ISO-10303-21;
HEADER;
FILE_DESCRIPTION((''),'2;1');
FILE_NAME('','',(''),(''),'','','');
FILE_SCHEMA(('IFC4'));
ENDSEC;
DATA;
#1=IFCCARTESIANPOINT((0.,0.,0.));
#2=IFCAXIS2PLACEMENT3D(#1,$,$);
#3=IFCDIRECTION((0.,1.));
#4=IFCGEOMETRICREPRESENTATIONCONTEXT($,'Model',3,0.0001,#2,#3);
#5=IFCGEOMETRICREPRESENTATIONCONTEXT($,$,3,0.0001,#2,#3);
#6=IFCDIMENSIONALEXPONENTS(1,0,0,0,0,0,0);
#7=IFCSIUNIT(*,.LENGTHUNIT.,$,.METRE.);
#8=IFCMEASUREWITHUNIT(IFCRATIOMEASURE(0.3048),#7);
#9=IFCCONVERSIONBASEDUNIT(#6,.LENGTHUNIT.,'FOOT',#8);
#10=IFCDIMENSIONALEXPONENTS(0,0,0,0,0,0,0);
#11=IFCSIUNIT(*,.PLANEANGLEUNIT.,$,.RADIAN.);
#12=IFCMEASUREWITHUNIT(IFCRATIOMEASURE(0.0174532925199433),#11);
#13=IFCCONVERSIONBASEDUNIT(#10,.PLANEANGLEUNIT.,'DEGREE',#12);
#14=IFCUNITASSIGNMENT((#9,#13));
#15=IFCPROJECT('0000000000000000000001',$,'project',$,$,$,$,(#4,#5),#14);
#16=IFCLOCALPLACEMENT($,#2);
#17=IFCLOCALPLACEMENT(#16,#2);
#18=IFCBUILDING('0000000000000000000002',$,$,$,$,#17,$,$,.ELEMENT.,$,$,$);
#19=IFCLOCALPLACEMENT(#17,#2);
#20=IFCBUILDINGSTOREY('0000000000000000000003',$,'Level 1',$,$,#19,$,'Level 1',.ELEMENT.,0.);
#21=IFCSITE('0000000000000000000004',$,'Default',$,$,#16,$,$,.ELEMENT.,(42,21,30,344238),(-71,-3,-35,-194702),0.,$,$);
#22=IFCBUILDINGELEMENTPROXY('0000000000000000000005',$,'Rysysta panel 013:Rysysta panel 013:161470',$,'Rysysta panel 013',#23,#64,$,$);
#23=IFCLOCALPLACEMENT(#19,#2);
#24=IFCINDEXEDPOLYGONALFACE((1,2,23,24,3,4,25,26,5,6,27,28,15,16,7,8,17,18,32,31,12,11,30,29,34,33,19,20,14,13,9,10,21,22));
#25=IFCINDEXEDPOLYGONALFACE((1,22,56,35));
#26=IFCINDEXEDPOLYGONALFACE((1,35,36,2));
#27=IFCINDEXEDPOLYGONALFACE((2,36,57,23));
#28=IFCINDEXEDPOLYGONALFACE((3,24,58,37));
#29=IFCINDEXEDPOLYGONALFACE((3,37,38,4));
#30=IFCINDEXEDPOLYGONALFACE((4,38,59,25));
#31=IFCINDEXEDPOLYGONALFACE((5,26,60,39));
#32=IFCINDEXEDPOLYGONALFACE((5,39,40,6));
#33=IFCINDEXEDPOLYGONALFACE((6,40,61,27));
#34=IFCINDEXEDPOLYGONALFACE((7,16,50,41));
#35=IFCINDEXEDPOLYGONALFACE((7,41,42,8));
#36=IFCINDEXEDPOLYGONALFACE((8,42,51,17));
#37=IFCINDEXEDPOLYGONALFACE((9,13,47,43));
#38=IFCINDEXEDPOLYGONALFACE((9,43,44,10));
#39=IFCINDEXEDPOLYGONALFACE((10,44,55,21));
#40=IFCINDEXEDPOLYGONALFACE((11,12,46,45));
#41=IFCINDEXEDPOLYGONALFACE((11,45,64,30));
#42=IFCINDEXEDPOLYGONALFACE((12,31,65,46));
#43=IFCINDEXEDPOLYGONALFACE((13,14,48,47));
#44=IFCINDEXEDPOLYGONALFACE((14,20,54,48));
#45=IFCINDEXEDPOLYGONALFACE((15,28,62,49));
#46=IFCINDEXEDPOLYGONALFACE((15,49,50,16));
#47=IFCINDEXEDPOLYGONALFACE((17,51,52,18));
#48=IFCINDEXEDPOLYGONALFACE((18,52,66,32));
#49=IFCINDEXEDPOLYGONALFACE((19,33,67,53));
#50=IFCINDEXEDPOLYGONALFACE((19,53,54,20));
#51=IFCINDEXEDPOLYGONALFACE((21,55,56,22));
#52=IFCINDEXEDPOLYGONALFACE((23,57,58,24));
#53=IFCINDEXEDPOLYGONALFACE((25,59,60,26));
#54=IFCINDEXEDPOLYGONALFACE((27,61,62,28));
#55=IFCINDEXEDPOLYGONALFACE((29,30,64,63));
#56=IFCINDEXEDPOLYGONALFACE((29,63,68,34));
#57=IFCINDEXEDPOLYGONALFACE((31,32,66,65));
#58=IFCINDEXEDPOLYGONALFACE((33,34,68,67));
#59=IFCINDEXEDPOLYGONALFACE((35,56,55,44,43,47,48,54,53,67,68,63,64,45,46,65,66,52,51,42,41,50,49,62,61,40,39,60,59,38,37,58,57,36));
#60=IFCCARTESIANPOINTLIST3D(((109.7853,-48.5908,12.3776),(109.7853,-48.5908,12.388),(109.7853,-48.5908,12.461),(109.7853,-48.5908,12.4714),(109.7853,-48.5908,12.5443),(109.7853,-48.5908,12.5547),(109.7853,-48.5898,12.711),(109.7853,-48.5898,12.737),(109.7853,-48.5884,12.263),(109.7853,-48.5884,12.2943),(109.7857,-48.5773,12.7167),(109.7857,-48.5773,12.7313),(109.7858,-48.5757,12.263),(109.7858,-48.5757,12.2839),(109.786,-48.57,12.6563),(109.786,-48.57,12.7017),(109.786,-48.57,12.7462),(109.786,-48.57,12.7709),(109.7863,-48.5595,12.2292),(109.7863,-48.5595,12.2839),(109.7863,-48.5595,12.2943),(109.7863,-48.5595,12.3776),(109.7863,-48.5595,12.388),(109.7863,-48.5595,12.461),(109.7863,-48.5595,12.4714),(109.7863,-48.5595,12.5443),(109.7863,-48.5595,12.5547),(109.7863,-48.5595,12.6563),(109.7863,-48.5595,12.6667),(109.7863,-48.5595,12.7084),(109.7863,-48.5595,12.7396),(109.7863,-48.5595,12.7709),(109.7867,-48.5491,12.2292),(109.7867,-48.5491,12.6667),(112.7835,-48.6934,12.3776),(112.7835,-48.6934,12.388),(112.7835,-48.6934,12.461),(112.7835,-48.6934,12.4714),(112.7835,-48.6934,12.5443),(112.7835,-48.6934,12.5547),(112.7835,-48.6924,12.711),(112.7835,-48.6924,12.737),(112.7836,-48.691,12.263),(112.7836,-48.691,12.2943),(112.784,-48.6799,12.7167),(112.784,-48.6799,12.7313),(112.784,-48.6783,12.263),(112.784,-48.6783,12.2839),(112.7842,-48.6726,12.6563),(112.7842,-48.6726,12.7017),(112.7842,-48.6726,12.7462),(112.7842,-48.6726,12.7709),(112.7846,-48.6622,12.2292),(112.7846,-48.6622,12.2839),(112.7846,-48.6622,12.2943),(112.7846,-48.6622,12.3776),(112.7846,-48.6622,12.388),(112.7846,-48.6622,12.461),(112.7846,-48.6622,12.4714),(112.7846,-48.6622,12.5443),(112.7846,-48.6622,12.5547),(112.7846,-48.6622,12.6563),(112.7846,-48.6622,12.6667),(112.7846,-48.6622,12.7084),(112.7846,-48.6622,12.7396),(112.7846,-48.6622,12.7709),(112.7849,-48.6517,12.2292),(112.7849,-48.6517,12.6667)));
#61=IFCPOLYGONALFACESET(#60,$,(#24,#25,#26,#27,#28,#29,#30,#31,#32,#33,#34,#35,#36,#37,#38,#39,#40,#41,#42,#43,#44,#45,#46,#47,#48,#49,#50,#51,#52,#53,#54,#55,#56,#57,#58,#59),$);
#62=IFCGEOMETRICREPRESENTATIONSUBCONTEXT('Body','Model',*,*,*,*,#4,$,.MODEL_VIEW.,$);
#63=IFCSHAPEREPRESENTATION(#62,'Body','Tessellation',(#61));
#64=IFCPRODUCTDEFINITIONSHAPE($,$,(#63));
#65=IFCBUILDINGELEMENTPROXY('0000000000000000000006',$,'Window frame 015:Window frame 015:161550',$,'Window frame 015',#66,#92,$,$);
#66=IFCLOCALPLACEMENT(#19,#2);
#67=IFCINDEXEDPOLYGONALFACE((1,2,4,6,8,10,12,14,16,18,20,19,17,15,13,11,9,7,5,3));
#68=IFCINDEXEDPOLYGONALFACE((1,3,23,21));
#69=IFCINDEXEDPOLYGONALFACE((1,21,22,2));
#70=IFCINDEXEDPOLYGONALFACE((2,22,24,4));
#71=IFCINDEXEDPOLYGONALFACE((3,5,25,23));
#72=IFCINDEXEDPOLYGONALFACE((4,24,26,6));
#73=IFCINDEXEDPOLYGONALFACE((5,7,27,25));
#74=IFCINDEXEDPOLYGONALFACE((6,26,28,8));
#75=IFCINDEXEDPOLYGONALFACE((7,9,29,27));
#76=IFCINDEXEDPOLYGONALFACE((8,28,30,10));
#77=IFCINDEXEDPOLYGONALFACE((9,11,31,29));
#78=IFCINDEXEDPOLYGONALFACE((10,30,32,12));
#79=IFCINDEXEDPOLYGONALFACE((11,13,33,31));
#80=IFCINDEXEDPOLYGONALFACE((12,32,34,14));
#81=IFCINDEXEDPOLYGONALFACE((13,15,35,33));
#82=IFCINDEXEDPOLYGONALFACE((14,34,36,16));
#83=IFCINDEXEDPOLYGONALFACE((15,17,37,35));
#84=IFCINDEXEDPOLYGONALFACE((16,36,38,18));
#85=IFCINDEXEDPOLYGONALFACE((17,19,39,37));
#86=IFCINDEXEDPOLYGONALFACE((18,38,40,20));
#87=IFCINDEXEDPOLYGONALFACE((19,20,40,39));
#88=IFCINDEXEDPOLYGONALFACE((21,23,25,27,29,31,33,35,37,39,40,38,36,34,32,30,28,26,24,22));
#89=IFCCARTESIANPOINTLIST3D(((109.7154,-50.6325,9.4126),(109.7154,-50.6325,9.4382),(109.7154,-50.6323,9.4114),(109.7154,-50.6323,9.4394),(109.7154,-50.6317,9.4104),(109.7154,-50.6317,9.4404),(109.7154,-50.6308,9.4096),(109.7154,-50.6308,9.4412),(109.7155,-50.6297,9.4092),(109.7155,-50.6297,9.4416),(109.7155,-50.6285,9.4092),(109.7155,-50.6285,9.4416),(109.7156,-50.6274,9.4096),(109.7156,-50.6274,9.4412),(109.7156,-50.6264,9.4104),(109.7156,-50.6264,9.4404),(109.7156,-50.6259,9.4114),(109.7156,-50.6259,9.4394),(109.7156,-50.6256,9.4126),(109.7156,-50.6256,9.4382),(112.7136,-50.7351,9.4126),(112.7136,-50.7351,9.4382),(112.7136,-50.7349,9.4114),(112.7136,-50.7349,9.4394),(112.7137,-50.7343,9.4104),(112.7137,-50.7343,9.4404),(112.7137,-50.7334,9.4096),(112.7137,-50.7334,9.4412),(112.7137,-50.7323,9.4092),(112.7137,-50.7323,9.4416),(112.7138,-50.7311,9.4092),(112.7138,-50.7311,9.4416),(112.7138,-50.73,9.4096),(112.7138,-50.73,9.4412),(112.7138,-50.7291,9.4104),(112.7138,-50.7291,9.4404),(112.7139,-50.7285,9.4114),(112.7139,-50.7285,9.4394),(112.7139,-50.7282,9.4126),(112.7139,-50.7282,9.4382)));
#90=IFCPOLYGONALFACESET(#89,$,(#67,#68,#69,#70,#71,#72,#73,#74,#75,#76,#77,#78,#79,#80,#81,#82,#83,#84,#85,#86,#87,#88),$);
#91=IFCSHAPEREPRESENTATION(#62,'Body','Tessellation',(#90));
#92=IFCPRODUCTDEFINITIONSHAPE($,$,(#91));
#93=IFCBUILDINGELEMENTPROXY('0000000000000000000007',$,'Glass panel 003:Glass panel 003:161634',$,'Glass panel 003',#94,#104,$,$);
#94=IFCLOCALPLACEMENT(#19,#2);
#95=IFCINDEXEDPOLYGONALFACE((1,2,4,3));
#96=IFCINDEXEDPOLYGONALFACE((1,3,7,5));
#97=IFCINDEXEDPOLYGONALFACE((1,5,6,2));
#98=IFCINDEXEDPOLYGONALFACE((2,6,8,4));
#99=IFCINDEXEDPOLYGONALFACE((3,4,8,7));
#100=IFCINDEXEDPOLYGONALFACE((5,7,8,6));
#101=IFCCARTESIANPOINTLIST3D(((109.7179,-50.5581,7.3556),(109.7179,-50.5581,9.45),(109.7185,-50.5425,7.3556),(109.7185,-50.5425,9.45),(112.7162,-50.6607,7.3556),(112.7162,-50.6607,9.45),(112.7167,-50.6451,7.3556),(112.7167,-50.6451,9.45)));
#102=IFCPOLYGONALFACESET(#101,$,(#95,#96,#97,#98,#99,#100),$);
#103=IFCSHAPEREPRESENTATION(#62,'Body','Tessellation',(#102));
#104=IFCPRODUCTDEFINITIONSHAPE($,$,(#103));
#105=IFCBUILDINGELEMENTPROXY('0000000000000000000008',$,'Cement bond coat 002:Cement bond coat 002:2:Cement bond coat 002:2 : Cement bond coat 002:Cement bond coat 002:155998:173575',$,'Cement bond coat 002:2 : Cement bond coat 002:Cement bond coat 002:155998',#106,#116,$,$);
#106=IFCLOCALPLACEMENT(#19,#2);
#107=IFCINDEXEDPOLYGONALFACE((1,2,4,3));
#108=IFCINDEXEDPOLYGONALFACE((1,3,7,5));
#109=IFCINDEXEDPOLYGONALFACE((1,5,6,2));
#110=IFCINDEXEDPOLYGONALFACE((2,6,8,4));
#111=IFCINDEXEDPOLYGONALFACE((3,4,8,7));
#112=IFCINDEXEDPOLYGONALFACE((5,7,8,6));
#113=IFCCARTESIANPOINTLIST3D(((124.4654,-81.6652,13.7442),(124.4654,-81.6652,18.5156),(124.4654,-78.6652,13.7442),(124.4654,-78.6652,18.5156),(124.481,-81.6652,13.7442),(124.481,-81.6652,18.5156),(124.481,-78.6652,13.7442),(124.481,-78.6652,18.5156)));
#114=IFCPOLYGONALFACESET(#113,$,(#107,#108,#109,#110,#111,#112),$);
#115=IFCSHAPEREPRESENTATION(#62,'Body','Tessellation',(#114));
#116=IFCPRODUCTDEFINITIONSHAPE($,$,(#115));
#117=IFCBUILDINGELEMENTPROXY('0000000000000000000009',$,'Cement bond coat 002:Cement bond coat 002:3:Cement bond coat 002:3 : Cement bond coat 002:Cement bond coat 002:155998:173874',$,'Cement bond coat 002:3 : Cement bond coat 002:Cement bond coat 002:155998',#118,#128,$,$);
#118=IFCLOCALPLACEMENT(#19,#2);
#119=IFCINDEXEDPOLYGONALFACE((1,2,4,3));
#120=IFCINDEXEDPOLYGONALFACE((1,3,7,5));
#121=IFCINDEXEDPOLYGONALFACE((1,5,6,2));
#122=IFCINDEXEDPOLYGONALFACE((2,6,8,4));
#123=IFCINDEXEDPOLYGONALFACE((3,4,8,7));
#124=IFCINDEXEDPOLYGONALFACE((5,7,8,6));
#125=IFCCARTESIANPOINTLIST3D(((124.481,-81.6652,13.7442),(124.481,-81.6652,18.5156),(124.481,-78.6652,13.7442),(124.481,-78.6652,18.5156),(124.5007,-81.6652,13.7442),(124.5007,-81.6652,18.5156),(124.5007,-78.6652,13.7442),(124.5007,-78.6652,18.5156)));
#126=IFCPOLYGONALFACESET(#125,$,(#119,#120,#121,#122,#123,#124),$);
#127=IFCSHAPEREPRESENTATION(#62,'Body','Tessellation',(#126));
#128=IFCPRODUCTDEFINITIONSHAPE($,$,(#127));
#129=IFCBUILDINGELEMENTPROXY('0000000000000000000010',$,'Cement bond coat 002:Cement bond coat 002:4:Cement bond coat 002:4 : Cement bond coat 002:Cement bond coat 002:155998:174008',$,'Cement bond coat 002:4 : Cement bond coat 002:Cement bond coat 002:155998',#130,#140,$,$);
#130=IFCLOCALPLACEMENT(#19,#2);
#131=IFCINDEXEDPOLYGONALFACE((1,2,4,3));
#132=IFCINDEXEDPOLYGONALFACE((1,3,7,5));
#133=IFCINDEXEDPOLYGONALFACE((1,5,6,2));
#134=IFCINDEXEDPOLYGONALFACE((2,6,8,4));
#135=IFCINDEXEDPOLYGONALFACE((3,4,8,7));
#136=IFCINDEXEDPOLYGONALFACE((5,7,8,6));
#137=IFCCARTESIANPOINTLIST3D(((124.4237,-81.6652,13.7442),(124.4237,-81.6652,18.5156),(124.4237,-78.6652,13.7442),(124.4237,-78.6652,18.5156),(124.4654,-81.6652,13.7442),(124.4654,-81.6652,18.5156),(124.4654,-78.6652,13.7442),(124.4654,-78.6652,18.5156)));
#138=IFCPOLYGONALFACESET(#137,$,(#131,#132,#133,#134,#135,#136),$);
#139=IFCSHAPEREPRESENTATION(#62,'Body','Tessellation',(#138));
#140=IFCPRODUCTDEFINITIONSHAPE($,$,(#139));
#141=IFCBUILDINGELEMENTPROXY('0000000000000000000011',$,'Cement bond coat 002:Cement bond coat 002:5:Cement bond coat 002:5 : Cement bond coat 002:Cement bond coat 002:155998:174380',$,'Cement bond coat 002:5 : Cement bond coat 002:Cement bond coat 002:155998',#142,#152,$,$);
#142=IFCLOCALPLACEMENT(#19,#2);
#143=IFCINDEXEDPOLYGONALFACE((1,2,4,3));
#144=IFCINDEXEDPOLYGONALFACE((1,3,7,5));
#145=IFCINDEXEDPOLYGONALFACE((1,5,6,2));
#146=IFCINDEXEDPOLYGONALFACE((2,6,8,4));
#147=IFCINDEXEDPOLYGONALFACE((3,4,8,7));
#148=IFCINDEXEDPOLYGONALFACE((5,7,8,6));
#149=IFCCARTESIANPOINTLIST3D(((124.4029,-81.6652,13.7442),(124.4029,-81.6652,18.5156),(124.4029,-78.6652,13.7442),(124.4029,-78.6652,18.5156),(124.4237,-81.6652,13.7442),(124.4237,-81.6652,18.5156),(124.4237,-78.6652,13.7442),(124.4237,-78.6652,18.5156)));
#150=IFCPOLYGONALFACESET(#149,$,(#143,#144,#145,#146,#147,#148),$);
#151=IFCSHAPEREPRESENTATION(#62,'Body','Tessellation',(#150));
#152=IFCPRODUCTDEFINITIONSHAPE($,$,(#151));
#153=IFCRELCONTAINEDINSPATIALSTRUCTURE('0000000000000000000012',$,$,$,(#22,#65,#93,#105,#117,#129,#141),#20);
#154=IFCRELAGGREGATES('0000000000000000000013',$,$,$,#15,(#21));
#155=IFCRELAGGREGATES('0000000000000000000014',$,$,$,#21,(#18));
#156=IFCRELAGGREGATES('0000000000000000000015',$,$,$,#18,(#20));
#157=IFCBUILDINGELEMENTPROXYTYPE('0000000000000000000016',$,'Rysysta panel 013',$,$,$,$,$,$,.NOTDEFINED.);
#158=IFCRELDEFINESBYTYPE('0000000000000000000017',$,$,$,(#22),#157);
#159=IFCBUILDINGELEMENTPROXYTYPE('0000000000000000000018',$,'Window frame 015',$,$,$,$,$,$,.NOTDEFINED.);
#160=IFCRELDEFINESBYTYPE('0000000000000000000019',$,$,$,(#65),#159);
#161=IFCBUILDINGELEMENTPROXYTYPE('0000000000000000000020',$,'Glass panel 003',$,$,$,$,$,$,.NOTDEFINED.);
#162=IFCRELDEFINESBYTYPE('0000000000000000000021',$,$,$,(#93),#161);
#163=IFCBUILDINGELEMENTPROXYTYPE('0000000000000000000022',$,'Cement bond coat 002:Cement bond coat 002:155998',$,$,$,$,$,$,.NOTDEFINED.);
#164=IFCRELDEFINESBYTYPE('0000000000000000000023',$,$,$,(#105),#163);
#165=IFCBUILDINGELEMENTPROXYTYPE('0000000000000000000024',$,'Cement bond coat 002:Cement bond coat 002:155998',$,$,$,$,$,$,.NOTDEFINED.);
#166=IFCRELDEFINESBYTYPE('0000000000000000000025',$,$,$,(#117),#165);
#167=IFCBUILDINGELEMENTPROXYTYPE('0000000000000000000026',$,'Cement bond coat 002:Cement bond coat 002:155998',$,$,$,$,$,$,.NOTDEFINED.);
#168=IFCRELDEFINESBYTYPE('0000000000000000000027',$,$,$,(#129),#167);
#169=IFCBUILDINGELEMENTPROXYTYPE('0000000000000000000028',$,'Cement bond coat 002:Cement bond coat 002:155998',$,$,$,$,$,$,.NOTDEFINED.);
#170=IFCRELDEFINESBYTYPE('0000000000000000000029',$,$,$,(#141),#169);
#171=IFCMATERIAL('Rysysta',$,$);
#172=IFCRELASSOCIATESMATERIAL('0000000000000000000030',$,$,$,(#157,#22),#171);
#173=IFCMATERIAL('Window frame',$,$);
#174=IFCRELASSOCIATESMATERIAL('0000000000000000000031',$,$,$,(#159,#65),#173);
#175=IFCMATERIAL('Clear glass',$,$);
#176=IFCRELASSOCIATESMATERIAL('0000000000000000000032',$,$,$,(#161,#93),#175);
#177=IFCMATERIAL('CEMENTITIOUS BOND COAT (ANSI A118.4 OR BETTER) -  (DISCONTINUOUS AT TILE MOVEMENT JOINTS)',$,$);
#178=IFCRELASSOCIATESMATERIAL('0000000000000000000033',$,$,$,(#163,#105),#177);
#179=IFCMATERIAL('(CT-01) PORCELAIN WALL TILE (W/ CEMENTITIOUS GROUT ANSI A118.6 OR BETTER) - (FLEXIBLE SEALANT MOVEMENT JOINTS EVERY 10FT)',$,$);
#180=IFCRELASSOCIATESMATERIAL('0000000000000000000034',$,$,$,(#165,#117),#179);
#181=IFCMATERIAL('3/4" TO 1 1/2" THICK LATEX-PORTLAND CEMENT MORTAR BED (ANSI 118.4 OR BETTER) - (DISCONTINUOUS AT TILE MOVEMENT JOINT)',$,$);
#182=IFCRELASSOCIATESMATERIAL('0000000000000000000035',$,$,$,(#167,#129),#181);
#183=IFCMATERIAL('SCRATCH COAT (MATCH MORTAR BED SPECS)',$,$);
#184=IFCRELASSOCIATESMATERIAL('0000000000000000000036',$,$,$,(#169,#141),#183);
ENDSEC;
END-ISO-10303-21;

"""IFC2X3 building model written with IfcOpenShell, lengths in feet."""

from ifc_helpers import new_model, entity, si_unit, converted_unit, direction, frame, frame_2d, origin, origin_2d_with_axis, place, context, subcontext, project, spatial, polyline, circle_curve, parameter, trimmed, segment, composite_curve, rectangle, outline, extrude, source, transform, mapped, material, type_object, type_shapes, element, save


model = new_model("IFC2X3")

# Units and contexts
model_context = context("Model", 3, precision=0.0001, world=origin(), true_north=direction((0.0, 1.0)))
context_of_model = context(None, 3, precision=0.0001, world=origin(), true_north=direction((0.0, 1.0)))
body_context = subcontext(model_context, "Body", "Model", "MODEL_VIEW")
ifc_project = project(units=[converted_unit("LENGTHUNIT", "FOOT", entity("IfcRatioMeasure", 0.3048), si_unit("LENGTHUNIT", "METRE"), dimensions=[1, 0, 0, 0, 0, 0, 0]), converted_unit("PLANEANGLEUNIT", "DEGREE", entity("IfcRatioMeasure", 0.0174532925199433), si_unit("PLANEANGLEUNIT", "RADIAN"), dimensions=[0, 0, 0, 0, 0, 0, 0])], contexts=[model_context, context_of_model])

# Site, building, storey
site_placement = place(None, origin())
site = spatial("IfcSite", under=ifc_project, at=site_placement, Name="Default", CompositionType="ELEMENT", RefLatitude=(42, 21, 30, 344238), RefLongitude=(-71, -3, -35, -194702), RefElevation=0.0)
building_placement = place(site_placement, origin())
building = spatial("IfcBuilding", under=site, at=building_placement, CompositionType="ELEMENT")
storey_placement = place(building_placement, origin())
storey = spatial("IfcBuildingStorey", under=building, at=storey_placement, Name="Level 1", LongName="Level 1", CompositionType="ELEMENT", Elevation=0.0)

# Building element proxies
ifc_material_1 = material(Name="Rysysta")
ifc_material_2 = material(Name="Window frame")
ifc_material_3 = material(Name="Clear glass")
building_element_proxy_type_1 = type_object("IfcBuildingElementProxyType", Name="Rysysta panel 013", PredefinedType="NOTDEFINED", material=ifc_material_1)
shared_shape_1 = source(origin(), body_context, "Body", "SweptSolid", [
    extrude(outline(polyline([(-0.022, 0.1457), (-0.022, -0.2918), (-0.0116, -0.2918), (-0.0116, -0.2371), (0.0045, -0.2371), (0.0045, -0.258), (0.0173, -0.258), (0.0173, -0.2267), (-0.0116, -0.2267), (-0.0116, -0.1434), (0.0196, -0.1434), (0.0196, -0.133), (-0.0116, -0.133), (-0.0116, -0.06), (0.0196, -0.06), (0.0196, -0.0496), (-0.0116, -0.0496), (-0.0116, 0.0233), (0.0196, 0.0233), (0.0196, 0.0337), (-0.0116, 0.0337), (-0.0116, 0.1353), (-0.0012, 0.1353), (-0.0012, 0.1807), (0.0186, 0.1899), (0.0186, 0.216), (-0.0012, 0.2252), (-0.0012, 0.2498), (-0.0116, 0.2498), (-0.0116, 0.2186), (0.0062, 0.2103), (0.0062, 0.1956), (-0.0116, 0.1873), (-0.0116, 0.1457), (-0.022, 0.1457)])), frame((109.7859, -48.5711, 12.521), z_axis=(-0.999415, 0.034202, 0.0), x_axis=(-0.034202, -0.999415, 0.0)), (0.0, 0.0, -1.0), 3.0),
])
type_shapes(building_element_proxy_type_1, [shared_shape_1])
proxy_1_placement = place(storey_placement, origin())
element("IfcBuildingElementProxy", 1, at=proxy_1_placement, inside=storey, type_object=building_element_proxy_type_1, material=ifc_material_1, Name="Rysysta panel 013:Rysysta panel 013:161470", ObjectType="Rysysta panel 013", context=body_context, shape_type="MappedRepresentation", body=[
    mapped(shared_shape_1, transform((0.0, 0.0, 0.0), scale=1.0)),
])
building_element_proxy_type_2 = type_object("IfcBuildingElementProxyType", Name="Window frame 015", PredefinedType="NOTDEFINED", material=ifc_material_2)
shared_shape_2 = source(origin(), body_context, "Body", "SweptSolid", [
    extrude(outline(composite_curve([segment(trimmed(circle_curve(frame_2d((0.0, 0.0128), x_axis=(1.0, 0.0)), 0.0034), [parameter(0.0)], [parameter(180.0)], True, "PARAMETER"), True, "CONTINUOUS"), segment(polyline([(-0.0034, 0.0128), (-0.0034, -0.0128)]), True, "CONTINUOUS"), segment(trimmed(circle_curve(frame_2d((0.0, -0.0128), x_axis=(1.0, 0.0)), 0.0034), [parameter(180.0)], [parameter(0.0)], True, "PARAMETER"), True, "CONTINUOUS"), segment(polyline([(0.0034, -0.0128), (0.0034, 0.0128)]), True, "CONTINUOUS")], self_intersect=False)), frame((109.7155, -50.6291, 9.4254), z_axis=(0.999415, -0.034202, 0.0), x_axis=(-0.034202, -0.999415, 0.0)), (0.0, 0.0, 1.0), 3.0),
])
type_shapes(building_element_proxy_type_2, [shared_shape_2])
proxy_2_placement = place(storey_placement, origin())
element("IfcBuildingElementProxy", 2, at=proxy_2_placement, inside=storey, type_object=building_element_proxy_type_2, material=ifc_material_2, Name="Window frame 015:Window frame 015:161550", ObjectType="Window frame 015", context=body_context, shape_type="MappedRepresentation", body=[
    mapped(shared_shape_2, transform((0.0, 0.0, 0.0), scale=1.0)),
])
building_element_proxy_type_3 = type_object("IfcBuildingElementProxyType", Name="Glass panel 003", PredefinedType="NOTDEFINED", material=ifc_material_3)
shared_shape_3 = source(origin(), body_context, "Body", "SweptSolid", [
    extrude(rectangle(XDim=3.0, YDim=0.0156, at=frame_2d((0.0, 0.0), x_axis=(1.0, 0.0))), frame((111.2173, -50.6016, 7.3556), z_axis=(0.0, 0.0, 1.0), x_axis=(-0.999415, 0.034202, 0.0)), (0.0, 0.0, 1.0), 2.0943),
])
type_shapes(building_element_proxy_type_3, [shared_shape_3])
proxy_3_placement = place(storey_placement, origin())
element("IfcBuildingElementProxy", 3, at=proxy_3_placement, inside=storey, type_object=building_element_proxy_type_3, material=ifc_material_3, Name="Glass panel 003:Glass panel 003:161634", ObjectType="Glass panel 003", context=body_context, shape_type="MappedRepresentation", body=[
    mapped(shared_shape_3, transform((0.0, 0.0, 0.0), scale=1.0)),
])
ifc_material_4 = material(Name="CEMENTITIOUS BOND COAT (ANSI A118.4 OR BETTER) -  (DISCONTINUOUS AT TILE MOVEMENT JOINTS)")
building_element_proxy_type_4 = type_object("IfcBuildingElementProxyType", Name="Cement bond coat 002:Cement bond coat 002:155998", PredefinedType="NOTDEFINED", material=ifc_material_4)
shared_shape_4 = source(origin(), body_context, "Body", "SweptSolid", [
    extrude(rectangle(XDim=3.0, YDim=0.0156, at=origin_2d_with_axis()), frame((124.4732, -80.1652, 13.7442), z_axis=(0.0, 0.0, 1.0), x_axis=(0.0, 1.0, 0.0)), (0.0, 0.0, 1.0), 4.7715),
])
type_shapes(building_element_proxy_type_4, [shared_shape_4])
proxy_4_placement = place(storey_placement, origin())
element("IfcBuildingElementProxy", 4, at=proxy_4_placement, inside=storey, type_object=building_element_proxy_type_4, material=ifc_material_4, Name="Cement bond coat 002:Cement bond coat 002:2:Cement bond coat 002:2 : Cement bond coat 002:Cement bond coat 002:155998:173575", ObjectType="Cement bond coat 002:2 : Cement bond coat 002:Cement bond coat 002:155998", context=body_context, shape_type="MappedRepresentation", body=[
    mapped(shared_shape_4, transform((0.0, 0.0, 0.0), scale=1.0)),
])
ifc_material_5 = material(Name="(CT-01) PORCELAIN WALL TILE (W/ CEMENTITIOUS GROUT ANSI A118.6 OR BETTER) - (FLEXIBLE SEALANT MOVEMENT JOINTS EVERY 10FT)")
building_element_proxy_type_5 = type_object("IfcBuildingElementProxyType", Name="Cement bond coat 002:Cement bond coat 002:155998", PredefinedType="NOTDEFINED", material=ifc_material_5)
shared_shape_5 = source(origin(), body_context, "Body", "SweptSolid", [
    extrude(rectangle(XDim=3.0, YDim=0.0197, at=frame_2d((0.0, 0.0), x_axis=(1.0, 0.0))), frame((124.4909, -80.1652, 13.7442), z_axis=(0.0, 0.0, 1.0), x_axis=(0.0, 1.0, 0.0)), (0.0, 0.0, 1.0), 4.7715),
])
type_shapes(building_element_proxy_type_5, [shared_shape_5])
proxy_5_placement = place(storey_placement, origin())
element("IfcBuildingElementProxy", 5, at=proxy_5_placement, inside=storey, type_object=building_element_proxy_type_5, material=ifc_material_5, Name="Cement bond coat 002:Cement bond coat 002:3:Cement bond coat 002:3 : Cement bond coat 002:Cement bond coat 002:155998:173874", ObjectType="Cement bond coat 002:3 : Cement bond coat 002:Cement bond coat 002:155998", context=body_context, shape_type="MappedRepresentation", body=[
    mapped(shared_shape_5, transform((0.0, 0.0, 0.0), scale=1.0)),
])
ifc_material_6 = material(Name="3/4\" TO 1 1/2\" THICK LATEX-PORTLAND CEMENT MORTAR BED (ANSI 118.4 OR BETTER) - (DISCONTINUOUS AT TILE MOVEMENT JOINT)")
building_element_proxy_type_6 = type_object("IfcBuildingElementProxyType", Name="Cement bond coat 002:Cement bond coat 002:155998", PredefinedType="NOTDEFINED", material=ifc_material_6)
shared_shape_6 = source(origin(), body_context, "Body", "SweptSolid", [
    extrude(rectangle(XDim=3.0, YDim=0.0417, at=frame_2d((0.0, 0.0), x_axis=(1.0, 0.0))), frame((124.4446, -80.1652, 13.7442), z_axis=(0.0, 0.0, 1.0), x_axis=(0.0, 1.0, 0.0)), (0.0, 0.0, 1.0), 4.7715),
])
type_shapes(building_element_proxy_type_6, [shared_shape_6])
proxy_6_placement = place(storey_placement, origin())
element("IfcBuildingElementProxy", 6, at=proxy_6_placement, inside=storey, type_object=building_element_proxy_type_6, material=ifc_material_6, Name="Cement bond coat 002:Cement bond coat 002:4:Cement bond coat 002:4 : Cement bond coat 002:Cement bond coat 002:155998:174008", ObjectType="Cement bond coat 002:4 : Cement bond coat 002:Cement bond coat 002:155998", context=body_context, shape_type="MappedRepresentation", body=[
    mapped(shared_shape_6, transform((0.0, 0.0, 0.0), scale=1.0)),
])
ifc_material_7 = material(Name="SCRATCH COAT (MATCH MORTAR BED SPECS)")
building_element_proxy_type_7 = type_object("IfcBuildingElementProxyType", Name="Cement bond coat 002:Cement bond coat 002:155998", PredefinedType="NOTDEFINED", material=ifc_material_7)
shared_shape_7 = source(origin(), body_context, "Body", "SweptSolid", [
    extrude(rectangle(XDim=3.0, YDim=0.0208, at=origin_2d_with_axis()), frame((124.4133, -80.1652, 13.7442), z_axis=(0.0, 0.0, 1.0), x_axis=(0.0, 1.0, 0.0)), (0.0, 0.0, 1.0), 4.7715),
])
type_shapes(building_element_proxy_type_7, [shared_shape_7])
proxy_7_placement = place(storey_placement, origin())
element("IfcBuildingElementProxy", 7, at=proxy_7_placement, inside=storey, type_object=building_element_proxy_type_7, material=ifc_material_7, Name="Cement bond coat 002:Cement bond coat 002:5:Cement bond coat 002:5 : Cement bond coat 002:Cement bond coat 002:155998:174380", ObjectType="Cement bond coat 002:5 : Cement bond coat 002:Cement bond coat 002:155998", context=body_context, shape_type="MappedRepresentation", body=[
    mapped(shared_shape_7, transform((0.0, 0.0, 0.0), scale=1.0)),
])

save(model, "model.ifc")
